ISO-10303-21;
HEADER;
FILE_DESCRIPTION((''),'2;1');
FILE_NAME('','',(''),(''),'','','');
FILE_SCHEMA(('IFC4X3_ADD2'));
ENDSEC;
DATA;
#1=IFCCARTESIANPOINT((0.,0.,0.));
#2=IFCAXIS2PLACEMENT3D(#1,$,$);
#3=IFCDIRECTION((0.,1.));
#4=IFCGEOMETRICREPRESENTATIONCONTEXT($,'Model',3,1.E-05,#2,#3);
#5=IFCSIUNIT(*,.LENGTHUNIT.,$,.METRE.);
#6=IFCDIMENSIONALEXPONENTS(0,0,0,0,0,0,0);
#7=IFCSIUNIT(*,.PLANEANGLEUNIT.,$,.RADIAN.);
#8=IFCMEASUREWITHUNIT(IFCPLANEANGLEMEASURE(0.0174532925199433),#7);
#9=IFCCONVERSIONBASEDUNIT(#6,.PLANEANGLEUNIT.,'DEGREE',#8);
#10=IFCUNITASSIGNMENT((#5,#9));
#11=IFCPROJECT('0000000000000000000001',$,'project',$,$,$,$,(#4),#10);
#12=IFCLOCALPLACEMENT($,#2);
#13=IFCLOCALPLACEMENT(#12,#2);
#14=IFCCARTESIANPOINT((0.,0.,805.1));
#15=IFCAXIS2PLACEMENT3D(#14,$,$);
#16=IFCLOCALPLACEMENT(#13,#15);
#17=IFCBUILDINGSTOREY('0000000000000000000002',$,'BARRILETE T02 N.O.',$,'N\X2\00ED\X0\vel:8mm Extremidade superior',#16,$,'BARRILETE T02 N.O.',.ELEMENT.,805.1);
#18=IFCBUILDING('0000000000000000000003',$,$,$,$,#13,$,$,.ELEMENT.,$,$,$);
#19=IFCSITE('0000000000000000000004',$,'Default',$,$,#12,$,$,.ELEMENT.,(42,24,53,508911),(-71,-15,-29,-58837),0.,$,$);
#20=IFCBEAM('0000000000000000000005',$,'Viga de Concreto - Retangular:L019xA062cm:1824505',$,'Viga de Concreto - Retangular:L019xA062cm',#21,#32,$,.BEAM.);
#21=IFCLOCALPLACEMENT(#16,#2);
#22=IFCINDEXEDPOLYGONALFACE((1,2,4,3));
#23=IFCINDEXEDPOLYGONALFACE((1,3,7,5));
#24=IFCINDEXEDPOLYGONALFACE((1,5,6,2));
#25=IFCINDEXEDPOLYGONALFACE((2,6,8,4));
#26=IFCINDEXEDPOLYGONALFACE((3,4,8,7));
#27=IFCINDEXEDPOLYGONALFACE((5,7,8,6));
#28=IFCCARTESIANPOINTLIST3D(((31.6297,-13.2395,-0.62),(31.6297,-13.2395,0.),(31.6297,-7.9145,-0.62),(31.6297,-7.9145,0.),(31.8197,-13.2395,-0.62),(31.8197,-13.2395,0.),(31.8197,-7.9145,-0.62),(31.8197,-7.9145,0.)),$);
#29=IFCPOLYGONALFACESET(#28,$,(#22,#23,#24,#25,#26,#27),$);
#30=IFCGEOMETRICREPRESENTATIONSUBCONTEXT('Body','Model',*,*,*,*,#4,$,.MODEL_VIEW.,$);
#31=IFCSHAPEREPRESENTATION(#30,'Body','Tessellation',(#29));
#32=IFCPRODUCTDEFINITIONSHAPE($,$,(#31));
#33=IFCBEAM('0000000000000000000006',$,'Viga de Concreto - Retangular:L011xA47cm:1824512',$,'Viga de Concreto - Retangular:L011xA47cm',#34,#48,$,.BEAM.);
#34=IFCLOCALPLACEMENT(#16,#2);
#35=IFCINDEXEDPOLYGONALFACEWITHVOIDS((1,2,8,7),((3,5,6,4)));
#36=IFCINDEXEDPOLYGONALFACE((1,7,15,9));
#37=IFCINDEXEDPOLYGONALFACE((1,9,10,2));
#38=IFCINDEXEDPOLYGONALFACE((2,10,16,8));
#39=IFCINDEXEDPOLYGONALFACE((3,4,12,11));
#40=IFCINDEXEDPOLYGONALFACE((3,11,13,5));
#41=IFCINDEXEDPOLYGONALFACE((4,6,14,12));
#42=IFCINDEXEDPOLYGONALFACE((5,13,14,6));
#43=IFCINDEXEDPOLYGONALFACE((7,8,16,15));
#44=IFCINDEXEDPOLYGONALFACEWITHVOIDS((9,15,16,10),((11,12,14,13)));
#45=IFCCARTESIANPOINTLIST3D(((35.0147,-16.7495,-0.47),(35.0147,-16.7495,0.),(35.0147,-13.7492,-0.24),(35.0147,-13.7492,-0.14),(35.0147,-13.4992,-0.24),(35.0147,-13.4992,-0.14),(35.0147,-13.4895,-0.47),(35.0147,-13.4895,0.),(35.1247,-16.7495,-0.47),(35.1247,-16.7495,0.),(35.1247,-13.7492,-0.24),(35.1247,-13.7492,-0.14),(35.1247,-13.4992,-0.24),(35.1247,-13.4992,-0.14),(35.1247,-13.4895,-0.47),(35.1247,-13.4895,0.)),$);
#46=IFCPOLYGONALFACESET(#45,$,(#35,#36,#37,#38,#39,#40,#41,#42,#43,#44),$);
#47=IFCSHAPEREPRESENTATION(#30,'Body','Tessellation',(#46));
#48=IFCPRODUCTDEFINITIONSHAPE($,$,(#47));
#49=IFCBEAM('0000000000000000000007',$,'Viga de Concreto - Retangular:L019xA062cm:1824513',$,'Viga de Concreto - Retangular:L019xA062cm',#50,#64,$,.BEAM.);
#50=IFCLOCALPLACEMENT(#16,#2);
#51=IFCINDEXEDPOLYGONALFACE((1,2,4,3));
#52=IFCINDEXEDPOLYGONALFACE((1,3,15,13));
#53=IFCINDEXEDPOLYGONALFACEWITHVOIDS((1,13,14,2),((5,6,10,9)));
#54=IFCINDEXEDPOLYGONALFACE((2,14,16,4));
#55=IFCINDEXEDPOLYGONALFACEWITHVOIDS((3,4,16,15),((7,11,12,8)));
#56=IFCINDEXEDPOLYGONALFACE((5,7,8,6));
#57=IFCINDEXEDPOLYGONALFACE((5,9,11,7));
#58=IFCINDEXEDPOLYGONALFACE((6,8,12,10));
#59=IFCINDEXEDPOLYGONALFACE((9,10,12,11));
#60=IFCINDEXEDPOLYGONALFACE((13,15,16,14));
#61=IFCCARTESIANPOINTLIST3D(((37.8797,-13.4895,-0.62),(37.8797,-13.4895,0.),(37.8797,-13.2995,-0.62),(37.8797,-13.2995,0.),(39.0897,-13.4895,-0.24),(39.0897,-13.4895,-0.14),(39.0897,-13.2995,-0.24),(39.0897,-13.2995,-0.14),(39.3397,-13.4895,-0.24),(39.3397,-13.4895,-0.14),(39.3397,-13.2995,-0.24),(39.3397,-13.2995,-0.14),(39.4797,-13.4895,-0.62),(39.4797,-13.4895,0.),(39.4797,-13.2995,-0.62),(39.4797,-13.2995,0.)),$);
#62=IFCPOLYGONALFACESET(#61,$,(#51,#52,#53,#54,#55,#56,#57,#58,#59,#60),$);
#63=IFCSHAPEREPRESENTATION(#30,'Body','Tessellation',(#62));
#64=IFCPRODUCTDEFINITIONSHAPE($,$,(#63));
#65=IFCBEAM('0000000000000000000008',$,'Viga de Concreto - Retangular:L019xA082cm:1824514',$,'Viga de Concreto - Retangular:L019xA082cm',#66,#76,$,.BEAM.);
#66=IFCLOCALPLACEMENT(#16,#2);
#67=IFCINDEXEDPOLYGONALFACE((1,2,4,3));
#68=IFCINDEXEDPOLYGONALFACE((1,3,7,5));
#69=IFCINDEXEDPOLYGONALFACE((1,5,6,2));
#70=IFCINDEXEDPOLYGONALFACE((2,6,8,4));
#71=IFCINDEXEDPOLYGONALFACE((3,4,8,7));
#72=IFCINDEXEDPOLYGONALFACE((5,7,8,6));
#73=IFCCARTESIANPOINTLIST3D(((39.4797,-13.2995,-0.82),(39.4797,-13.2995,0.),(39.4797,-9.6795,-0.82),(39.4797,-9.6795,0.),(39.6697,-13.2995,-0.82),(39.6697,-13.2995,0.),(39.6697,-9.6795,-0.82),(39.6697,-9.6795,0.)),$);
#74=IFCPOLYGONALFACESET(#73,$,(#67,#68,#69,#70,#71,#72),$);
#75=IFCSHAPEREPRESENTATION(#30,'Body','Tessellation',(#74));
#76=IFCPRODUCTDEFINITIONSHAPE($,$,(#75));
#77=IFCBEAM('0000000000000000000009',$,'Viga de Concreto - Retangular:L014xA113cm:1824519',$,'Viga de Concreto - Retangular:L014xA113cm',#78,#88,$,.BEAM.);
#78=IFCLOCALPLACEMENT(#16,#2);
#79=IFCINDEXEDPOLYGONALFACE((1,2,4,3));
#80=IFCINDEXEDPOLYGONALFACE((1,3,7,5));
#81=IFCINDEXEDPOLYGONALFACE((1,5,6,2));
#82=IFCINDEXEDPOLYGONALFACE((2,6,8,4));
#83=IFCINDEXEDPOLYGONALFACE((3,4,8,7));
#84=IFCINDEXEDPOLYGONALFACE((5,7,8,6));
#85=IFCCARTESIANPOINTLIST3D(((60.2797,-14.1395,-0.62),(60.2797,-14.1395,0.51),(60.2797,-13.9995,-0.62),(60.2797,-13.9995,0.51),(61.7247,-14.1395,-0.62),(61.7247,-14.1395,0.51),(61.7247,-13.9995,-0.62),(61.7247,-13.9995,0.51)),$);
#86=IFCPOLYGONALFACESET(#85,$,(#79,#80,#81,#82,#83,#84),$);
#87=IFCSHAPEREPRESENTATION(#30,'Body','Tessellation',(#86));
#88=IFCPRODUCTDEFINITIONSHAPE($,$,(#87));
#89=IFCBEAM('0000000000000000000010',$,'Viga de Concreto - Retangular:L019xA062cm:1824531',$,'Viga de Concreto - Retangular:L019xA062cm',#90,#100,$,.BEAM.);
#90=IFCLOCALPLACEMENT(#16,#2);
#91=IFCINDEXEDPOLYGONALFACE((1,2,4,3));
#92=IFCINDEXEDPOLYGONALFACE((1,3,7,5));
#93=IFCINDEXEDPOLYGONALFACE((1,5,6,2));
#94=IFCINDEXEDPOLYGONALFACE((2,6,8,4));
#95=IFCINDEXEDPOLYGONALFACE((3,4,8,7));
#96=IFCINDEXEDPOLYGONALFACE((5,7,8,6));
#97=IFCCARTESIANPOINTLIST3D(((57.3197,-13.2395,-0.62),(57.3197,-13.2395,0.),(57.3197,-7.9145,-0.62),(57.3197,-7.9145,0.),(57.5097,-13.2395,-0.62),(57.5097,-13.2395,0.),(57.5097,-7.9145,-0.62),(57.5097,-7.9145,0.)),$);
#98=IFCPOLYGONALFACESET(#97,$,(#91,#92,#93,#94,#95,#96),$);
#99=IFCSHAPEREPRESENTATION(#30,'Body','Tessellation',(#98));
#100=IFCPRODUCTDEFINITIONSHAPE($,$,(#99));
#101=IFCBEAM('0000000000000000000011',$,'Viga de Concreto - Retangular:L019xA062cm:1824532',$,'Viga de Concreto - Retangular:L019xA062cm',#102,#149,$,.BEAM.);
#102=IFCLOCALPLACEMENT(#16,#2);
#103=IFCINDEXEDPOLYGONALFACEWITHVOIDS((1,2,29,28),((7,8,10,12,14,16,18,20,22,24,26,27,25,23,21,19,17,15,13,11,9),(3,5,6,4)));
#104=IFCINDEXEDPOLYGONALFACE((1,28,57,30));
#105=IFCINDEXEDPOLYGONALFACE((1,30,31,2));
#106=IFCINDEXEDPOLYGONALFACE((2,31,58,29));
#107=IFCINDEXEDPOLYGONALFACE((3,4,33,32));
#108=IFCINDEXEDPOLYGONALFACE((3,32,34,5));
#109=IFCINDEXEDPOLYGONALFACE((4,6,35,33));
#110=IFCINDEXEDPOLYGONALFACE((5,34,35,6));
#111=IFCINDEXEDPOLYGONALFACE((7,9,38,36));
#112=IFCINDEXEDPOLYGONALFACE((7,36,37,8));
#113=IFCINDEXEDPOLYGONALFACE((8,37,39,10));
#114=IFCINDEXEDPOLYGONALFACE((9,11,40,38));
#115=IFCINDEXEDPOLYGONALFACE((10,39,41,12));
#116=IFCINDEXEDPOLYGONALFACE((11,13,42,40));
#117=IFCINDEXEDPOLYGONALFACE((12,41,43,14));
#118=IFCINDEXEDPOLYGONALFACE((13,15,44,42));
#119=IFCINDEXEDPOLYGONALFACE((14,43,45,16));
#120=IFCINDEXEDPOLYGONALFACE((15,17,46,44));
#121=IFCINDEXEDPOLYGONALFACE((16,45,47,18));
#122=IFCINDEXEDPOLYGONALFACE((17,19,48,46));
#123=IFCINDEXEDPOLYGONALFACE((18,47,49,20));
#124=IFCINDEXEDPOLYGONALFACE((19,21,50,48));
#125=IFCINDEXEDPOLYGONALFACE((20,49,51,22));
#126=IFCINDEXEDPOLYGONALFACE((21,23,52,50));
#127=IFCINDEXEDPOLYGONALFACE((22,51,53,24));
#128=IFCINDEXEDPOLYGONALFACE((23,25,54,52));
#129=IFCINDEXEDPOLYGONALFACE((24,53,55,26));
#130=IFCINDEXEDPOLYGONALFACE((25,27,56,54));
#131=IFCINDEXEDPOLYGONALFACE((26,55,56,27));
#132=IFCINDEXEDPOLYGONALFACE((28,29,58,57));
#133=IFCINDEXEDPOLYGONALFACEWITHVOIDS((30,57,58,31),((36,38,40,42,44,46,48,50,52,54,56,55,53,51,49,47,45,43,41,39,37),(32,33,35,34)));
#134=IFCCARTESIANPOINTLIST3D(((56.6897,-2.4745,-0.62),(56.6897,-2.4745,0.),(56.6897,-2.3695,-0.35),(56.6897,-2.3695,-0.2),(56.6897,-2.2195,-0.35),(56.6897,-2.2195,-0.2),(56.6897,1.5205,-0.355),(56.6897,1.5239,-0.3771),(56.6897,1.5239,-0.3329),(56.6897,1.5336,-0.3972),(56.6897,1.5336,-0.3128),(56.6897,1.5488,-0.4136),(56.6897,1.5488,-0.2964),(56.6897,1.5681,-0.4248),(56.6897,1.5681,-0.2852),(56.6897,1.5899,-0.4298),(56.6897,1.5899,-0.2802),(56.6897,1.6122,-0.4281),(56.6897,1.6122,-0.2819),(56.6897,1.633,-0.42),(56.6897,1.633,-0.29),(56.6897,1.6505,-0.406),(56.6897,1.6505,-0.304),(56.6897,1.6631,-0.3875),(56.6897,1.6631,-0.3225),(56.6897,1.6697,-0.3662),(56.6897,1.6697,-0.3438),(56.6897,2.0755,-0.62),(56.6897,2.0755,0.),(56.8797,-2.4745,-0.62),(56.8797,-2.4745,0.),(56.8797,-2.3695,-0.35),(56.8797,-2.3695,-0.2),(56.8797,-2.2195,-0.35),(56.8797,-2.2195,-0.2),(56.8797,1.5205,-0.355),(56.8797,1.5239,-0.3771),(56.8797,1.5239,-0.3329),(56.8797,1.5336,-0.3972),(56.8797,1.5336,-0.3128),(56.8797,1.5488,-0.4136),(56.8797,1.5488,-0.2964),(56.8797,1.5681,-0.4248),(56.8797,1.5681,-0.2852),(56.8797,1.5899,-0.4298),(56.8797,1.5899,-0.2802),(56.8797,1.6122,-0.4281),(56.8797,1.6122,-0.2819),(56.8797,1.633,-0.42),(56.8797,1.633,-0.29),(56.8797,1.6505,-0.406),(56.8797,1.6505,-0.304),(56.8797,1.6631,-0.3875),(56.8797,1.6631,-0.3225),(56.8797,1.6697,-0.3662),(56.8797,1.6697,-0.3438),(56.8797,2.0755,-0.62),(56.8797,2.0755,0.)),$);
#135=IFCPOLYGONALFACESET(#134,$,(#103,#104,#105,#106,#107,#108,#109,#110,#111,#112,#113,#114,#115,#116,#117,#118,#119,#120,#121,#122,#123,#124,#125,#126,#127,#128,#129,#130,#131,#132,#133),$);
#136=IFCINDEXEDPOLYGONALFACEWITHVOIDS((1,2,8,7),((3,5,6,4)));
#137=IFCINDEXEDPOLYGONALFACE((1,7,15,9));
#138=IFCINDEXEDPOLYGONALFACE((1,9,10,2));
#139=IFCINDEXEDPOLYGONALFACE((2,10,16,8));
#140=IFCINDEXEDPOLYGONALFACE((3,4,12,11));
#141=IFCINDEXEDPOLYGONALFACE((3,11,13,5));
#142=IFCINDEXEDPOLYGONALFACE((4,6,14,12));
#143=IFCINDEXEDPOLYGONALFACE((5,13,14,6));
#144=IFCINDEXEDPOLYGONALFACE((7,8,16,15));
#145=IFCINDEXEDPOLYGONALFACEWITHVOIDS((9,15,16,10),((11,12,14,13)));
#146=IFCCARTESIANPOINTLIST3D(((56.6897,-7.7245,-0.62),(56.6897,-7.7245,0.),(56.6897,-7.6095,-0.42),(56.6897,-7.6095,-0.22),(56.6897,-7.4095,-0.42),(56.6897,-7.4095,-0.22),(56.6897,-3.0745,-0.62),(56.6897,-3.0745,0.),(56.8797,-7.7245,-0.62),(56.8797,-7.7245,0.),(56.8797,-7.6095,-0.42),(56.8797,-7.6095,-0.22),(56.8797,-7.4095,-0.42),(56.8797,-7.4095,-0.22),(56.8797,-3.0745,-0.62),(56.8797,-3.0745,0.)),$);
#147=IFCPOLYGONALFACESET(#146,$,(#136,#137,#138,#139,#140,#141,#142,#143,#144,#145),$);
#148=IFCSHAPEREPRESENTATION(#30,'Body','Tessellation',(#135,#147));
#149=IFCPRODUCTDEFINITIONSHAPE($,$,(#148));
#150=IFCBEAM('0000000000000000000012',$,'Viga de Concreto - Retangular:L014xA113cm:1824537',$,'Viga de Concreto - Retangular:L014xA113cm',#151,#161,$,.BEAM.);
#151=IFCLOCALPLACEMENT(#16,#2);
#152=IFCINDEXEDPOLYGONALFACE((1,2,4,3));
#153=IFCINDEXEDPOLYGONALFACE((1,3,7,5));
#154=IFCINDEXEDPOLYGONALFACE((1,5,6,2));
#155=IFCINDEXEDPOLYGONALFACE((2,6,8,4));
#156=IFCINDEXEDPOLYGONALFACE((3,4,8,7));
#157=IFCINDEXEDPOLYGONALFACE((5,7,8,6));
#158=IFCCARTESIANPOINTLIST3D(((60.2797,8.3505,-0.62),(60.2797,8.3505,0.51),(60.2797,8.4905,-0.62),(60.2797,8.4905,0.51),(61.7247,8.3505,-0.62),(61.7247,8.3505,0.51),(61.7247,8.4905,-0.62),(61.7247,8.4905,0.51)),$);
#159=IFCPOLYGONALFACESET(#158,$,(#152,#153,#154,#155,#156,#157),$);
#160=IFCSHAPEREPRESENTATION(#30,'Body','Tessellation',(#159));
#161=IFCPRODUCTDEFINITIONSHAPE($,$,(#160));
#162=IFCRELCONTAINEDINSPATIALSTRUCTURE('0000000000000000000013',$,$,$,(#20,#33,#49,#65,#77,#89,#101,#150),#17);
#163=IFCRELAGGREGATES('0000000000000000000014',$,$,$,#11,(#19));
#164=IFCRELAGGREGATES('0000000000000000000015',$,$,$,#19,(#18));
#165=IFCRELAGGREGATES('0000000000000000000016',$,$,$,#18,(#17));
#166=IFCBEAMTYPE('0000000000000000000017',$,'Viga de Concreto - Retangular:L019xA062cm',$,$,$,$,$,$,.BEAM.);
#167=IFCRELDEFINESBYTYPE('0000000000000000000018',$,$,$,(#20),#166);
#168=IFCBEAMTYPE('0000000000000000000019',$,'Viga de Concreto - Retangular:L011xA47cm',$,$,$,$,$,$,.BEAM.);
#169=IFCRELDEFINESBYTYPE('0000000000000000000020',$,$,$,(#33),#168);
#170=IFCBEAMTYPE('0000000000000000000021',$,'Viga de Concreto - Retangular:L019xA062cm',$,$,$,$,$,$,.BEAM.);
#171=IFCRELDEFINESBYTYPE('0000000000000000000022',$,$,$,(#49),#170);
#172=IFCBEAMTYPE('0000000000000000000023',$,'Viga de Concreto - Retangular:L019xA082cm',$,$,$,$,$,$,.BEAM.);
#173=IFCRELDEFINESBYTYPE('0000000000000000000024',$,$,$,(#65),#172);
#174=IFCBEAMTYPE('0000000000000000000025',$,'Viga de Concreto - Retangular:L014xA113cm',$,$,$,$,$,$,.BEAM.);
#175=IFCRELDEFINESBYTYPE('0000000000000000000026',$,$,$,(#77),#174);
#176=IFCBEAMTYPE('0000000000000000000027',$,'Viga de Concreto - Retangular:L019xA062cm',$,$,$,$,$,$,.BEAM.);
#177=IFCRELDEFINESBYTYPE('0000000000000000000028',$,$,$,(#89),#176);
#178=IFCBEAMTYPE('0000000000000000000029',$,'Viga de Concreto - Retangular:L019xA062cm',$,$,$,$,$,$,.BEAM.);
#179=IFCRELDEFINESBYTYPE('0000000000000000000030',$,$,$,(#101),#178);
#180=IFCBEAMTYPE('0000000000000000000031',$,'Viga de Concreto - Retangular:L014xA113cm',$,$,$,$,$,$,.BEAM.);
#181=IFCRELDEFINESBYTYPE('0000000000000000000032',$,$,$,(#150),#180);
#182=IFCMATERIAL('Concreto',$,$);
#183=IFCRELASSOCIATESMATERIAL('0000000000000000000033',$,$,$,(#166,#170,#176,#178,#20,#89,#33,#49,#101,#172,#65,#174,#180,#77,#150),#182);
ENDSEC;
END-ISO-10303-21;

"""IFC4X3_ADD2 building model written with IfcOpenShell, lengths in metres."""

from ifc_helpers import new_model, entity, si_unit, converted_unit, direction, frame, frame_2d, origin, origin_2d_with_axis, place, context, subcontext, project, spatial, rectangle, circle, extrude, boolean, source, transform, mapped, material, material_profile, profile_set, profile_usage, type_object, type_shapes, element, save


model = new_model("IFC4X3_ADD2")

# Units and contexts
model_context = context("Model", 3, precision=1e-05, world=origin(), true_north=direction((0.0, 1.0)))
body_context = subcontext(model_context, "Body", "Model", "MODEL_VIEW")
ifc_project = project(units=[si_unit("LENGTHUNIT", "METRE"), converted_unit("PLANEANGLEUNIT", "DEGREE", entity("IfcPlaneAngleMeasure", 0.0174532925199433), si_unit("PLANEANGLEUNIT", "RADIAN"), dimensions=[0, 0, 0, 0, 0, 0, 0])], contexts=[model_context])

# Site, building, storey
site_placement = place(None, origin())
site = spatial("IfcSite", under=ifc_project, at=site_placement, Name="Default", CompositionType="ELEMENT", RefLatitude=(42, 24, 53, 508911), RefLongitude=(-71, -15, -29, -58837), RefElevation=0.0)
building_placement = place(site_placement, origin())
building = spatial("IfcBuilding", under=site, at=building_placement, CompositionType="ELEMENT")
storey_placement = place(building_placement, frame((0.0, 0.0, 805.1)))
storey = spatial("IfcBuildingStorey", under=building, at=storey_placement, Name="BARRILETE T02 N.O.", ObjectType="Nível:8mm Extremidade superior", LongName="BARRILETE T02 N.O.", CompositionType="ELEMENT", Elevation=805.1)

# Beams
ifc_material = material(Name="Concreto")
ifc_material_profile_1 = material_profile(ifc_material, rectangle(XDim=0.62, YDim=0.19, at=frame_2d((0.0, 0.0), x_axis=(0.0, 1.0))), Name="L019xA062cm")
ifc_profile_set_1 = profile_set([ifc_material_profile_1], Name="L019xA062cm")
ifc_profile_usage_1 = profile_usage(ifc_profile_set_1, cardinal=8)
beam_type_1 = type_object("IfcBeamType", Name="Viga de Concreto - Retangular:L019xA062cm", PredefinedType="BEAM", material=ifc_profile_set_1)
shared_shape_1 = source(origin(), body_context, "Body", "SweptSolid", [
    extrude(rectangle(XDim=0.62, YDim=0.19, at=frame_2d((0.0, 0.0), x_axis=(0.0, 1.0))), frame((31.7247, -13.2395, 804.79), z_axis=(0.0, 1.0, 0.0), x_axis=(-1.0, 0.0, 0.0)), (0.0, 0.0, 1.0), 5.325),
])
type_shapes(beam_type_1, [shared_shape_1])
beam_1_placement = place(storey_placement, frame((0.0, 0.0, -805.1)))
element("IfcBeam", 1, at=beam_1_placement, inside=storey, type_object=beam_type_1, material=ifc_profile_usage_1, Name="Viga de Concreto - Retangular:L019xA062cm:1824505", ObjectType="Viga de Concreto - Retangular:L019xA062cm", PredefinedType="BEAM", context=body_context, shape_type="MappedRepresentation", body=[
    mapped(shared_shape_1, transform((0.0, 0.0, 0.0), scale=1.0)),
])
beam_type_2 = type_object("IfcBeamType", Name="Viga de Concreto - Retangular:L011xA47cm", PredefinedType="BEAM")
shared_shape_2 = source(origin(), body_context, "Body", "CSG", [
    boolean("DIFFERENCE", extrude(rectangle(XDim=0.47, YDim=0.11, at=frame_2d((0.0, 0.0), x_axis=(0.0, 1.0))), frame((35.0697, -13.4895, 804.865), z_axis=(0.0, -1.0, 0.0), x_axis=(-1.0, 0.0, 0.0)), (0.0, 0.0, 1.0), 3.26), extrude(rectangle(XDim=0.1, YDim=0.25, at=frame_2d((0.0, 0.0), x_axis=(0.0, 1.0))), frame((35.1247, -13.6242, 804.91), z_axis=(-1.0, 0.0, 0.0), x_axis=(0.0, 1.0, 0.0)), (0.0, 0.0, 1.0), 0.11)),
])
type_shapes(beam_type_2, [shared_shape_2])
beam_2_placement = place(storey_placement, frame((0.0, 0.0, -805.1)))
element("IfcBeam", 2, at=beam_2_placement, inside=storey, type_object=beam_type_2, material=ifc_material, Name="Viga de Concreto - Retangular:L011xA47cm:1824512", ObjectType="Viga de Concreto - Retangular:L011xA47cm", PredefinedType="BEAM", context=body_context, shape_type="MappedRepresentation", body=[
    mapped(shared_shape_2, transform((0.0, 0.0, 0.0), scale=1.0)),
])
beam_type_3 = type_object("IfcBeamType", Name="Viga de Concreto - Retangular:L019xA062cm", PredefinedType="BEAM", material=ifc_profile_set_1)
shared_shape_3 = source(origin(), body_context, "Body", "CSG", [
    boolean("DIFFERENCE", extrude(rectangle(XDim=0.62, YDim=0.19, at=frame_2d((0.0, 0.0), x_axis=(0.0, 1.0))), frame((37.8797, -13.3945, 804.79), z_axis=(1.0, 0.0, 0.0), x_axis=(0.0, 1.0, 0.0)), (0.0, 0.0, 1.0), 1.6), extrude(rectangle(XDim=0.1, YDim=0.25, at=frame_2d((0.0, 0.0), x_axis=(0.0, 1.0))), frame((39.2147, -13.2995, 804.91), z_axis=(0.0, -1.0, 0.0), x_axis=(-1.0, 0.0, 0.0)), (0.0, 0.0, 1.0), 0.19)),
])
type_shapes(beam_type_3, [shared_shape_3])
beam_3_placement = place(storey_placement, frame((0.0, 0.0, -805.1)))
element("IfcBeam", 3, at=beam_3_placement, inside=storey, type_object=beam_type_3, material=ifc_material, Name="Viga de Concreto - Retangular:L019xA062cm:1824513", ObjectType="Viga de Concreto - Retangular:L019xA062cm", PredefinedType="BEAM", context=body_context, shape_type="MappedRepresentation", body=[
    mapped(shared_shape_3, transform((0.0, 0.0, 0.0), scale=1.0)),
])
ifc_material_profile_2 = material_profile(ifc_material, rectangle(XDim=0.82, YDim=0.19, at=frame_2d((0.0, 0.0), x_axis=(0.0, 1.0))), Name="L019xA082cm")
ifc_profile_set_2 = profile_set([ifc_material_profile_2], Name="L019xA082cm")
ifc_profile_usage_2 = profile_usage(ifc_profile_set_2, cardinal=8)
beam_type_4 = type_object("IfcBeamType", Name="Viga de Concreto - Retangular:L019xA082cm", PredefinedType="BEAM", material=ifc_profile_set_2)
shared_shape_4 = source(origin(), body_context, "Body", "SweptSolid", [
    extrude(rectangle(XDim=0.82, YDim=0.19, at=frame_2d((0.0, 0.0), x_axis=(0.0, 1.0))), frame((39.5747, -13.2995, 804.69), z_axis=(0.0, 1.0, 0.0), x_axis=(-1.0, 0.0, 0.0)), (0.0, 0.0, 1.0), 3.62),
])
type_shapes(beam_type_4, [shared_shape_4])
beam_4_placement = place(storey_placement, frame((0.0, 0.0, -805.1)))
element("IfcBeam", 4, at=beam_4_placement, inside=storey, type_object=beam_type_4, material=ifc_profile_usage_2, Name="Viga de Concreto - Retangular:L019xA082cm:1824514", ObjectType="Viga de Concreto - Retangular:L019xA082cm", PredefinedType="BEAM", context=body_context, shape_type="MappedRepresentation", body=[
    mapped(shared_shape_4, transform((0.0, 0.0, 0.0), scale=1.0)),
])
ifc_material_profile_3 = material_profile(ifc_material, rectangle(XDim=1.13, YDim=0.14, at=origin_2d_with_axis()), Name="L014xA113cm")
ifc_profile_set_3 = profile_set([ifc_material_profile_3], Name="L014xA113cm")
ifc_profile_usage_3 = profile_usage(ifc_profile_set_3, cardinal=8)
beam_type_5 = type_object("IfcBeamType", Name="Viga de Concreto - Retangular:L014xA113cm", PredefinedType="BEAM", material=ifc_profile_set_3)
shared_shape_5 = source(origin(), body_context, "Body", "SweptSolid", [
    extrude(rectangle(XDim=1.13, YDim=0.14, at=origin_2d_with_axis()), frame((61.7247, -14.0695, 805.045), z_axis=(-1.0, 0.0, 0.0), x_axis=(0.0, 0.0, -1.0)), (0.0, 0.0, 1.0), 1.445),
])
type_shapes(beam_type_5, [shared_shape_5])
beam_5_placement = place(storey_placement, frame((0.0, 0.0, -805.1)))
element("IfcBeam", 5, at=beam_5_placement, inside=storey, type_object=beam_type_5, material=ifc_profile_usage_3, Name="Viga de Concreto - Retangular:L014xA113cm:1824519", ObjectType="Viga de Concreto - Retangular:L014xA113cm", PredefinedType="BEAM", context=body_context, shape_type="MappedRepresentation", body=[
    mapped(shared_shape_5, transform((0.0, 0.0, 0.0), scale=1.0)),
])
beam_type_6 = type_object("IfcBeamType", Name="Viga de Concreto - Retangular:L019xA062cm", PredefinedType="BEAM", material=ifc_profile_set_1)
shared_shape_6 = source(origin(), body_context, "Body", "SweptSolid", [
    extrude(rectangle(XDim=0.62, YDim=0.19, at=frame_2d((0.0, 0.0), x_axis=(0.0, 1.0))), frame((57.4147, -13.2395, 804.79), z_axis=(0.0, 1.0, 0.0), x_axis=(-1.0, 0.0, 0.0)), (0.0, 0.0, 1.0), 5.325),
])
type_shapes(beam_type_6, [shared_shape_6])
beam_6_placement = place(storey_placement, frame((0.0, 0.0, -805.1)))
element("IfcBeam", 6, at=beam_6_placement, inside=storey, type_object=beam_type_6, material=ifc_profile_usage_1, Name="Viga de Concreto - Retangular:L019xA062cm:1824531", ObjectType="Viga de Concreto - Retangular:L019xA062cm", PredefinedType="BEAM", context=body_context, shape_type="MappedRepresentation", body=[
    mapped(shared_shape_6, transform((0.0, 0.0, 0.0), scale=1.0)),
])
beam_type_7 = type_object("IfcBeamType", Name="Viga de Concreto - Retangular:L019xA062cm", PredefinedType="BEAM", material=ifc_profile_set_1)
shared_shape_7 = source(origin(), body_context, "Body", "CSG", [
    boolean("DIFFERENCE", boolean("DIFFERENCE", extrude(rectangle(XDim=0.62, YDim=0.19, at=frame_2d((0.0, 0.0), x_axis=(0.0, 1.0))), frame((56.7847, -2.4745, 804.79), z_axis=(0.0, 1.0, 0.0), x_axis=(-1.0, 0.0, 0.0)), (0.0, 0.0, 1.0), 4.55), extrude(circle(Radius=0.075, at=origin_2d_with_axis()), frame((56.8797, 1.5955, 804.745), z_axis=(-1.0, 0.0, 0.0), x_axis=(0.0, -1.0, 0.0)), (0.0, 0.0, 1.0), 0.19)), extrude(rectangle(XDim=0.15, YDim=0.15, at=frame_2d((0.0, 0.0), x_axis=(0.0, 1.0))), frame((56.8797, -2.2945, 804.825), z_axis=(-1.0, 0.0, 0.0), x_axis=(0.0, 1.0, 0.0)), (0.0, 0.0, 1.0), 0.19)),
    boolean("DIFFERENCE", extrude(rectangle(XDim=0.62, YDim=0.19, at=frame_2d((0.0, 0.0), x_axis=(0.0, 1.0))), frame((56.7847, -7.7245, 804.79), z_axis=(0.0, 1.0, 0.0), x_axis=(-1.0, 0.0, 0.0)), (0.0, 0.0, 1.0), 4.65), extrude(rectangle(XDim=0.2, YDim=0.2, at=frame_2d((0.0, 0.0), x_axis=(0.0, 1.0))), frame((56.8797, -7.5095, 804.78), z_axis=(-1.0, 0.0, 0.0), x_axis=(0.0, 1.0, 0.0)), (0.0, 0.0, 1.0), 0.19)),
])
type_shapes(beam_type_7, [shared_shape_7])
beam_7_placement = place(storey_placement, frame((0.0, 0.0, -805.1)))
element("IfcBeam", 7, at=beam_7_placement, inside=storey, type_object=beam_type_7, material=ifc_material, Name="Viga de Concreto - Retangular:L019xA062cm:1824532", ObjectType="Viga de Concreto - Retangular:L019xA062cm", PredefinedType="BEAM", context=body_context, shape_type="MappedRepresentation", body=[
    mapped(shared_shape_7, transform((0.0, 0.0, 0.0), scale=1.0)),
])
beam_type_8 = type_object("IfcBeamType", Name="Viga de Concreto - Retangular:L014xA113cm", PredefinedType="BEAM", material=ifc_profile_set_3)
shared_shape_8 = source(origin(), body_context, "Body", "SweptSolid", [
    extrude(rectangle(XDim=1.13, YDim=0.14, at=frame_2d((0.0, 0.0), x_axis=(1.0, 0.0))), frame((60.2797, 8.4205, 805.045), z_axis=(1.0, 0.0, 0.0), x_axis=(0.0, 0.0, -1.0)), (0.0, 0.0, 1.0), 1.445),
])
type_shapes(beam_type_8, [shared_shape_8])
beam_8_placement = place(storey_placement, frame((0.0, 0.0, -805.1)))
element("IfcBeam", 8, at=beam_8_placement, inside=storey, type_object=beam_type_8, material=ifc_profile_usage_3, Name="Viga de Concreto - Retangular:L014xA113cm:1824537", ObjectType="Viga de Concreto - Retangular:L014xA113cm", PredefinedType="BEAM", context=body_context, shape_type="MappedRepresentation", body=[
    mapped(shared_shape_8, transform((0.0, 0.0, 0.0), scale=1.0)),
])

save(model, "model.ifc")
